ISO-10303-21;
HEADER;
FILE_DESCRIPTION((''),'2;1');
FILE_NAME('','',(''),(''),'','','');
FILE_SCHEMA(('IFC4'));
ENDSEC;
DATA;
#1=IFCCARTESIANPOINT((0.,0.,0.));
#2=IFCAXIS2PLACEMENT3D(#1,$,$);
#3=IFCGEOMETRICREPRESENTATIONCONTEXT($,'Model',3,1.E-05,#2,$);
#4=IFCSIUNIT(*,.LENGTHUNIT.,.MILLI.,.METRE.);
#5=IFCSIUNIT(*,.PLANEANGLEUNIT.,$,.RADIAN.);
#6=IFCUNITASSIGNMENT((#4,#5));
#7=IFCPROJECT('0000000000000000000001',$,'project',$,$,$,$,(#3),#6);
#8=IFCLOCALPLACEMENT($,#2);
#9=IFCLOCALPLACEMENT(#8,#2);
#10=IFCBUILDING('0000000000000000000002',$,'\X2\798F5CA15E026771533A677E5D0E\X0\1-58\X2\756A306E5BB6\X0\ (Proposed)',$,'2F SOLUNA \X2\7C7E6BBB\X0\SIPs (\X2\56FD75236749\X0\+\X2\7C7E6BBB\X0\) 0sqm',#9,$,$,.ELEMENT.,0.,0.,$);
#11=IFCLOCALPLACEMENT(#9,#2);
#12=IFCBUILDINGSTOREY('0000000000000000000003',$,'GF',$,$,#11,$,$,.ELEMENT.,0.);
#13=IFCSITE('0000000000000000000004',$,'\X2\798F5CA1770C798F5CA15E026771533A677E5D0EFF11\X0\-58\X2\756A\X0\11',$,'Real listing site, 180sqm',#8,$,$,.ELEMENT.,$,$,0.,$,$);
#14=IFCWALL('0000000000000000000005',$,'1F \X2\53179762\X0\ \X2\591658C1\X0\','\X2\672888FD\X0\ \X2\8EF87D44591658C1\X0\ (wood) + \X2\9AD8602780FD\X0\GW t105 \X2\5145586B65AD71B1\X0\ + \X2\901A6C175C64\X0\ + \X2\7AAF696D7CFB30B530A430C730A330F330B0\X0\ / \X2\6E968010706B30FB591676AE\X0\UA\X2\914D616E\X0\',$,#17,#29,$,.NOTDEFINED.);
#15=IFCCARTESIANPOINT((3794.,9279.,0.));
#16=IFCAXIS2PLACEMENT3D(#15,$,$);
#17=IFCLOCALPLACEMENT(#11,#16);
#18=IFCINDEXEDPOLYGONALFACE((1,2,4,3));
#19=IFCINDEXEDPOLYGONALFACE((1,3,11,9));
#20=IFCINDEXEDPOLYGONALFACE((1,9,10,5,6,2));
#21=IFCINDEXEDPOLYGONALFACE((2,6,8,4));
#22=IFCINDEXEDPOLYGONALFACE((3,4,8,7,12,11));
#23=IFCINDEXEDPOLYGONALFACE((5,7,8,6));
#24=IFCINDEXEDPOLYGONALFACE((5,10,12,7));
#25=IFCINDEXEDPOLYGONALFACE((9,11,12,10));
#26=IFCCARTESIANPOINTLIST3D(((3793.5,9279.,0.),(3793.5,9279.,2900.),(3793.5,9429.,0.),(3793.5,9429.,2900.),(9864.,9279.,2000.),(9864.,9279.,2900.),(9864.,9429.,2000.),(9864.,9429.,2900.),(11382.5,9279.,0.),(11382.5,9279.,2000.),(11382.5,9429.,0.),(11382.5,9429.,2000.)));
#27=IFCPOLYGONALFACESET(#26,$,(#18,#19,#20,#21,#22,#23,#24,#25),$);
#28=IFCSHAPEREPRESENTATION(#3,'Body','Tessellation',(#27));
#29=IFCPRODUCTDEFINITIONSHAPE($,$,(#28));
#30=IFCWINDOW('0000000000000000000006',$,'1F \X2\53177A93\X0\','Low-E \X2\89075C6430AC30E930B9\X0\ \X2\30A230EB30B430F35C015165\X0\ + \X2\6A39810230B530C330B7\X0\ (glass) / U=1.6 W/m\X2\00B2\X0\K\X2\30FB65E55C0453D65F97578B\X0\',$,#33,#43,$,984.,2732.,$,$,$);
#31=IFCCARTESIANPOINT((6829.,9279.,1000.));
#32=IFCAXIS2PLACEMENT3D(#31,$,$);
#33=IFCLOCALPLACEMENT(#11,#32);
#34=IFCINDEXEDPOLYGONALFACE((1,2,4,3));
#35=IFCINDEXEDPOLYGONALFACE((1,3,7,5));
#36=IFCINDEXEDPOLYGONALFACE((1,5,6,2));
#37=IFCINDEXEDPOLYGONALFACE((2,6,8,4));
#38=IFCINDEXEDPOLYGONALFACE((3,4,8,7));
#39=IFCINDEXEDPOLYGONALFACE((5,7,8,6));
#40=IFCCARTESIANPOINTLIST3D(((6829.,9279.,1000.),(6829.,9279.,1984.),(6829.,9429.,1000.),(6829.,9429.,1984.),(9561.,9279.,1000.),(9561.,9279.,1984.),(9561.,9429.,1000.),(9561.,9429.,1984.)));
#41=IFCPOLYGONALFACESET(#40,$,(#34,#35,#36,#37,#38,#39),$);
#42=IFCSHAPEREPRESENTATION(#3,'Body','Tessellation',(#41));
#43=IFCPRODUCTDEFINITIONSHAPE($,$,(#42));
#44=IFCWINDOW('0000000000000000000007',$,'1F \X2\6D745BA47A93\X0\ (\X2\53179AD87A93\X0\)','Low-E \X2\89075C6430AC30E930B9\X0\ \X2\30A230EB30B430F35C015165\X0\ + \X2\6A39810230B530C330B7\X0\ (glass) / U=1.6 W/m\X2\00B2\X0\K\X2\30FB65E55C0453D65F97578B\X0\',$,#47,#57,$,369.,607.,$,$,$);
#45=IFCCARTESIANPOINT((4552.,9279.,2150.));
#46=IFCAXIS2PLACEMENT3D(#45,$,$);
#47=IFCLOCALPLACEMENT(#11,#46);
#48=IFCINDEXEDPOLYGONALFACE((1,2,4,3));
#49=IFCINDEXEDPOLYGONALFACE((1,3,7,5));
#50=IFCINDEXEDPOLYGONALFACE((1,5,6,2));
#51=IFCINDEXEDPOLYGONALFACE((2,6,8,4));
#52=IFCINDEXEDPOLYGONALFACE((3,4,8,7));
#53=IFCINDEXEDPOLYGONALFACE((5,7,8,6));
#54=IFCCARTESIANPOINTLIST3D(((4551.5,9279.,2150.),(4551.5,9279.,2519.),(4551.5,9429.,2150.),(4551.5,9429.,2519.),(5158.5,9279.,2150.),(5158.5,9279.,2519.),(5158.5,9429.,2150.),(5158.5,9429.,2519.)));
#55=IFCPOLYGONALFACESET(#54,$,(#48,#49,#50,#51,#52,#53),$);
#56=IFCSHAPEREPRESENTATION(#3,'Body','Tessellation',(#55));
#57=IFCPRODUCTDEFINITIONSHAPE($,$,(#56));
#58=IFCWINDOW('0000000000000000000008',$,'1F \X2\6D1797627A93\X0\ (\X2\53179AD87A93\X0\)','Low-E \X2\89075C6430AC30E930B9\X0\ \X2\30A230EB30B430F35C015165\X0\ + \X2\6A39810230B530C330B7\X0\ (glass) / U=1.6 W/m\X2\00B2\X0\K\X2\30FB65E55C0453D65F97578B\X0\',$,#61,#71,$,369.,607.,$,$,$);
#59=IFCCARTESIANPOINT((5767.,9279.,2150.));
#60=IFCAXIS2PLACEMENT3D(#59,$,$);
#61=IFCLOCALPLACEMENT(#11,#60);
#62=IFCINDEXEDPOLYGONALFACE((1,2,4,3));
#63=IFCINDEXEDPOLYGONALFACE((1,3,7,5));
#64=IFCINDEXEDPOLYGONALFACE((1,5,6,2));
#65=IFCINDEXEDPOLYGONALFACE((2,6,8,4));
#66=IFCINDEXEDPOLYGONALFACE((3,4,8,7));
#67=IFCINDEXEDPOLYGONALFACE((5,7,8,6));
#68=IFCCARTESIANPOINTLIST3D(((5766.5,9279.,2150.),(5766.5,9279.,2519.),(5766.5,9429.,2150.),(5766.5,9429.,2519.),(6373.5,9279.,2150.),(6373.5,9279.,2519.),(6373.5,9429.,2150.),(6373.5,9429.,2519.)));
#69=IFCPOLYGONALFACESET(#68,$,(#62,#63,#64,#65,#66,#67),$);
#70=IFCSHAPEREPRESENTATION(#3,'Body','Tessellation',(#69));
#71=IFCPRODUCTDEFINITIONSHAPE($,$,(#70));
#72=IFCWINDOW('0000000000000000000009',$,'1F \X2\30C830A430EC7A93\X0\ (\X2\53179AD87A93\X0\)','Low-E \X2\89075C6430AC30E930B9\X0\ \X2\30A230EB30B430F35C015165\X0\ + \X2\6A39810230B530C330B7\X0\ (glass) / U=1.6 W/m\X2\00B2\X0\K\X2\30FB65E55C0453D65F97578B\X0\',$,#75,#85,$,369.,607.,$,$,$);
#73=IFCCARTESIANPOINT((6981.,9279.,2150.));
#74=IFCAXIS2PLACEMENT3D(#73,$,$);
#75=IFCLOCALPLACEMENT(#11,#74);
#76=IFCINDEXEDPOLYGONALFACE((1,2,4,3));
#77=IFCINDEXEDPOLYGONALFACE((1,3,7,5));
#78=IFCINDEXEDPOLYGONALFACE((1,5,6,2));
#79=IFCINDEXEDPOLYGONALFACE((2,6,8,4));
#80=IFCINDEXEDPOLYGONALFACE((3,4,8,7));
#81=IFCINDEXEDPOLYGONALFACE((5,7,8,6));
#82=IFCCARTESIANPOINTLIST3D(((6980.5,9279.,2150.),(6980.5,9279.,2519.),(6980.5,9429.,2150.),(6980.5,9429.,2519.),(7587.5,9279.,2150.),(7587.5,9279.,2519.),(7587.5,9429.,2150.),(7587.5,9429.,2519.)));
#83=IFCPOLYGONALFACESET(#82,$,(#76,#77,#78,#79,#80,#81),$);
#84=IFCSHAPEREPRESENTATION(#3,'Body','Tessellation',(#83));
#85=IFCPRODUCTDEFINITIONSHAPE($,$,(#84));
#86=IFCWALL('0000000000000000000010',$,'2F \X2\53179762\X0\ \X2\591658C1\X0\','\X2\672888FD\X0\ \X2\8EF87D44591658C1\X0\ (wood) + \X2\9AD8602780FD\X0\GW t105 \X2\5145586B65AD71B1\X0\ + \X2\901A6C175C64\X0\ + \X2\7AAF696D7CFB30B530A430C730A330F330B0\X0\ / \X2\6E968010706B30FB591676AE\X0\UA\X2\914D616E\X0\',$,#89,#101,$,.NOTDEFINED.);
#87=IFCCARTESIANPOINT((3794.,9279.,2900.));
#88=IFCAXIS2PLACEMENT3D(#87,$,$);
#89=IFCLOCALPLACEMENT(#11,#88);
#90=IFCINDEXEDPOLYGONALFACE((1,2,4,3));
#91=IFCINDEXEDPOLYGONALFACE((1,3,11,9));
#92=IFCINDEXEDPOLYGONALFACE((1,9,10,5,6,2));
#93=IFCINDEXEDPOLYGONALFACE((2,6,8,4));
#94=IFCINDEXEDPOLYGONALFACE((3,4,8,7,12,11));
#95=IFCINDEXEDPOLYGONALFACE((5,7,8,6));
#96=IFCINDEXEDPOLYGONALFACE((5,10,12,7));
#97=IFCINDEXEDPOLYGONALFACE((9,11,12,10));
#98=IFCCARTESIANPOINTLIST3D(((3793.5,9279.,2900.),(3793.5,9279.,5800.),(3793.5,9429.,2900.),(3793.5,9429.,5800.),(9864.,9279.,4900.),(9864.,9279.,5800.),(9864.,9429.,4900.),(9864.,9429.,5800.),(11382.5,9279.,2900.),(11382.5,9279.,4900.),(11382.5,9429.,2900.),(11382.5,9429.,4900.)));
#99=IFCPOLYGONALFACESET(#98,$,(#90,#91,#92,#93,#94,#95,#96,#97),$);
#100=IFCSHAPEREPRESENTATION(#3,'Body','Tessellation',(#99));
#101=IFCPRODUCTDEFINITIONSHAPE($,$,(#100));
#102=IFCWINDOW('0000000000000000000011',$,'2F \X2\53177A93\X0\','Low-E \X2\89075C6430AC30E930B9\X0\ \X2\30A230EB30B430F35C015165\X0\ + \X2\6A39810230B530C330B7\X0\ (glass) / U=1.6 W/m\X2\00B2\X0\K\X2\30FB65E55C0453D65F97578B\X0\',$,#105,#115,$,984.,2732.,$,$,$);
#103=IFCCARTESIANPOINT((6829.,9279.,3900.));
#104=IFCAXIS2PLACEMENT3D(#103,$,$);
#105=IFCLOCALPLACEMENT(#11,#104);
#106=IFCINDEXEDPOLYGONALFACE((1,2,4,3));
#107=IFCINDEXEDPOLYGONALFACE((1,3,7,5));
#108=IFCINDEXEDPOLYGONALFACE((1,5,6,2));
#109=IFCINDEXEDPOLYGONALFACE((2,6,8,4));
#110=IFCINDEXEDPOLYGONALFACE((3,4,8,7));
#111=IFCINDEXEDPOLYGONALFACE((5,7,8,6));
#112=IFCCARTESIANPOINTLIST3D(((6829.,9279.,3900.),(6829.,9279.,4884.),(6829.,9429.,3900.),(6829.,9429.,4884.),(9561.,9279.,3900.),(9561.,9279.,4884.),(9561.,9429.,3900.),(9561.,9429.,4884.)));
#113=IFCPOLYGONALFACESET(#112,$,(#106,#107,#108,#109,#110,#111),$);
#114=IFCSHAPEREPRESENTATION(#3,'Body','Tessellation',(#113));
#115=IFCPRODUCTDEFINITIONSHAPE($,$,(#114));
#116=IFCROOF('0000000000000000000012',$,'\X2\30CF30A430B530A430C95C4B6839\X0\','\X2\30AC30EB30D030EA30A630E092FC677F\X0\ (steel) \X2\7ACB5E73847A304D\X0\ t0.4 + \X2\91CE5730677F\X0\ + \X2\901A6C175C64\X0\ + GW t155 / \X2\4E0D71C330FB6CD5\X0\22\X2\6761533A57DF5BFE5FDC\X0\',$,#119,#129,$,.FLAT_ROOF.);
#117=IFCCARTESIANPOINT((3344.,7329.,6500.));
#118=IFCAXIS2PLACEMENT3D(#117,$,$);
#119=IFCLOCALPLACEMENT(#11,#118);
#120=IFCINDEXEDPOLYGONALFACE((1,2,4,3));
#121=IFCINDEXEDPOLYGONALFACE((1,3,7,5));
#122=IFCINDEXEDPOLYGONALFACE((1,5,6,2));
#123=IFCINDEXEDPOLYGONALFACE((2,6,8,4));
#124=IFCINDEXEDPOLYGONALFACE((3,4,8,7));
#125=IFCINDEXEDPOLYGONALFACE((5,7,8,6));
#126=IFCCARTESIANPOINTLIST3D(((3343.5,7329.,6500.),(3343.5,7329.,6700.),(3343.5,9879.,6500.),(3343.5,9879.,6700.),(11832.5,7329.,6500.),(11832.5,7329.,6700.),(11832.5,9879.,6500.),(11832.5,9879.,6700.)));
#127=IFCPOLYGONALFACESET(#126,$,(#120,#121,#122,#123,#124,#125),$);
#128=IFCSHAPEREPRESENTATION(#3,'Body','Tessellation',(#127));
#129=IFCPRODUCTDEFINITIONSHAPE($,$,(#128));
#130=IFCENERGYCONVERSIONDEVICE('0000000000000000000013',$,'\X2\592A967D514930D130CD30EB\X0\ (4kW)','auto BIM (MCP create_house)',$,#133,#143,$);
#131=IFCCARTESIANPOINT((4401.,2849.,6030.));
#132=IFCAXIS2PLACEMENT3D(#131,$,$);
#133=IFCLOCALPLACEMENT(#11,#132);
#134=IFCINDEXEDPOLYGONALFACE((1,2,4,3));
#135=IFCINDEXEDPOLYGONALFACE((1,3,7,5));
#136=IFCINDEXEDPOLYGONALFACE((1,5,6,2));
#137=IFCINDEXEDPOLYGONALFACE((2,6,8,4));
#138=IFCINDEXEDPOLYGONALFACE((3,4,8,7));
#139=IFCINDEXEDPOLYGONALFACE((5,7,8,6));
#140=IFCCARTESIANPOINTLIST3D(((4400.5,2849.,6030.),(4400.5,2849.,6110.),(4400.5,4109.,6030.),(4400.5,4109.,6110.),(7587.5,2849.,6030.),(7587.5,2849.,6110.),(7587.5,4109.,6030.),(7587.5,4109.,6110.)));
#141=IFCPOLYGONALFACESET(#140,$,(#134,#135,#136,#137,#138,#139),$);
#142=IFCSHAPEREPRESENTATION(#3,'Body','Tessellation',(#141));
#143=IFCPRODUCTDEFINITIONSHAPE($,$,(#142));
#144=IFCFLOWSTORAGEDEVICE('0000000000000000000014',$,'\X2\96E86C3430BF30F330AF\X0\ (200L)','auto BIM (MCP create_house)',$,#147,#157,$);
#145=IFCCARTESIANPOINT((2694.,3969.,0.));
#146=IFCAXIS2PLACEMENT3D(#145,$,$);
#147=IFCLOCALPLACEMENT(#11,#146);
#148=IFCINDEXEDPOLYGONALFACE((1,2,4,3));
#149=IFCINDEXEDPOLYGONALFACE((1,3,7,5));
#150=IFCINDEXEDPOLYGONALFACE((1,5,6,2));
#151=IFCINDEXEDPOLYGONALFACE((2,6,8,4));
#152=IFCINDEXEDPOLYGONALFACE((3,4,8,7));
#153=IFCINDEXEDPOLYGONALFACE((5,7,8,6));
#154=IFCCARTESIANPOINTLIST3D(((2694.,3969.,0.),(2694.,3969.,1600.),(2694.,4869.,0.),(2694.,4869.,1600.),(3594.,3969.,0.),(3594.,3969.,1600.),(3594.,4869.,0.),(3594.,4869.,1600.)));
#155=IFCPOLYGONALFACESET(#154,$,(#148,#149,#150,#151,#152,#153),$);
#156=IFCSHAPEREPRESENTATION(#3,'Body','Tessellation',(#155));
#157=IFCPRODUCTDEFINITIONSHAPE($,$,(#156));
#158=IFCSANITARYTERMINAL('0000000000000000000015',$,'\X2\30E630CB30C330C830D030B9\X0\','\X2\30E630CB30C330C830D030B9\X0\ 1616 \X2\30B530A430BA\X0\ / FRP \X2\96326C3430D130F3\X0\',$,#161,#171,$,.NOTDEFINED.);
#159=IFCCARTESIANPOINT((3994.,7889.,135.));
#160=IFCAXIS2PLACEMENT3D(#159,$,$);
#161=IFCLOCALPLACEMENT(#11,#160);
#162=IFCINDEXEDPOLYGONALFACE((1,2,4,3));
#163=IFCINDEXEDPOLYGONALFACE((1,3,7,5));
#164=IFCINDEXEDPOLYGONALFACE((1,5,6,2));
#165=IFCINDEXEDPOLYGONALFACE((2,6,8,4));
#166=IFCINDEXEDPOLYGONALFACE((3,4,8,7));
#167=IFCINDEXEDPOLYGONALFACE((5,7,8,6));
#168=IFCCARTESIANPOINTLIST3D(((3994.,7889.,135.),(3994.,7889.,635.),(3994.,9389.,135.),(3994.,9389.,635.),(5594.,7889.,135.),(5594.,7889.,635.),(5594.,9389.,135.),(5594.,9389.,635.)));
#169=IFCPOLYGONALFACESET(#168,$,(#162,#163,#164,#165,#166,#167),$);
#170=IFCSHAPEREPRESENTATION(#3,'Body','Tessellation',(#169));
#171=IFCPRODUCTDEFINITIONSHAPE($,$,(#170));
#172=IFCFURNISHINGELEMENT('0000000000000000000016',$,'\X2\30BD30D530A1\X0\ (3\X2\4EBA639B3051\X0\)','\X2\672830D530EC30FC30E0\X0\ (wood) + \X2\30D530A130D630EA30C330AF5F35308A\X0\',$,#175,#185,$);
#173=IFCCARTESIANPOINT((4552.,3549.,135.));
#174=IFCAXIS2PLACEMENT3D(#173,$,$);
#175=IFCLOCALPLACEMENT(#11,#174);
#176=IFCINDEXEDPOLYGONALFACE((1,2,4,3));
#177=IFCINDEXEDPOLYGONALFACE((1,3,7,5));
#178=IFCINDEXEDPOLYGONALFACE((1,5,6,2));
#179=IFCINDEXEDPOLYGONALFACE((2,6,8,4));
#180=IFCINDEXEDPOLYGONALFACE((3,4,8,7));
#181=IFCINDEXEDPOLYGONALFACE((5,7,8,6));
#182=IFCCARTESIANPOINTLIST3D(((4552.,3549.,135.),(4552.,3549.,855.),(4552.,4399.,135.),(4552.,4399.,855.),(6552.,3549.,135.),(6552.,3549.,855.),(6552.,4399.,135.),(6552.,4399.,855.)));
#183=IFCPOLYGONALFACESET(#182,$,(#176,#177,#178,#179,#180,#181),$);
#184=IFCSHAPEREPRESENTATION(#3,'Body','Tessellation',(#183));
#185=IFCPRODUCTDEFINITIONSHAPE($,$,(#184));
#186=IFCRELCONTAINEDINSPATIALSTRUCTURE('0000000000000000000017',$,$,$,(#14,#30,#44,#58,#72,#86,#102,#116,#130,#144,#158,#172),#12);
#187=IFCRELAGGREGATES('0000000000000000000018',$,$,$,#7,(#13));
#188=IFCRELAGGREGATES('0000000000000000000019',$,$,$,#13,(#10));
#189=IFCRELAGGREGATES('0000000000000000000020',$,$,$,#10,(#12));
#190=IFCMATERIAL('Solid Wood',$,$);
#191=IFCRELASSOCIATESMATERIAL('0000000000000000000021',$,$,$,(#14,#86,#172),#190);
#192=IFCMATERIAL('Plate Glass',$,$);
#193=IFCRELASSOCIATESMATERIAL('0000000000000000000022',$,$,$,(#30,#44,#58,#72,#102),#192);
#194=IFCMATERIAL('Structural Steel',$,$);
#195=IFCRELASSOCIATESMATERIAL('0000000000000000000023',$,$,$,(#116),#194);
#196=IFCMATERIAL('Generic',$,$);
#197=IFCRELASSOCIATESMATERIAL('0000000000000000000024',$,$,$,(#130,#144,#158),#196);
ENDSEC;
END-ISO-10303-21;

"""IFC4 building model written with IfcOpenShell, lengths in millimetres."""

from ifc_helpers import new_model, si_unit, frame, frame_2d, origin, place, context, project, spatial, rectangle, extrude, material, element, fill, save


model = new_model("IFC4")

# Units and contexts
model_context = context("Model", 3, precision=1e-05, world=origin())
ifc_project = project(units=[si_unit("LENGTHUNIT", "METRE", prefix="MILLI"), si_unit("PLANEANGLEUNIT", "RADIAN")], contexts=[model_context])

# Site, building, storey
site_placement = place(None, origin())
site = spatial("IfcSite", under=ifc_project, at=site_placement, Name="福岡県福岡市東区松崎１-58番11", ObjectType="Real listing site, 180sqm", CompositionType="ELEMENT", RefElevation=0.0)
building_placement = place(site_placement, origin())
building = spatial("IfcBuilding", under=site, at=building_placement, Name="福岡市東区松崎1-58番の家 (Proposed)", ObjectType="2F SOLUNA 籾殻SIPs (国産杉+籾殻) 0sqm", CompositionType="ELEMENT", ElevationOfRefHeight=0.0, ElevationOfTerrain=0.0)
storey_placement = place(building_placement, origin())
storey = spatial("IfcBuildingStorey", under=building, at=storey_placement, Name="GF", CompositionType="ELEMENT", Elevation=0.0)

# Wall, openings, windows
ifc_material_1 = material(Name="Solid Wood")
wall_1_placement = place(storey_placement, frame((3794.0, 9279.0, 0.0)))
wall_1 = element("IfcWall", 1, at=wall_1_placement, inside=storey, material=ifc_material_1, Name="1F 北面 外壁", Description="木製 軸組外壁 (wood) + 高性能GW t105 充填断熱 + 通気層 + 窯業系サイディング / 準耐火・外皮UA配慮", PredefinedType="NOTDEFINED", context=model_context, shape_type="SweptSolid", body=[
    extrude(rectangle(XDim=7589.0, YDim=150.0, at=frame_2d((3794.0, 75.0))), frame((3794.0, 9279.0, 0.0)), (0.0, 0.0, 1.0), 2900.0),
])
opening_1_placement = place(storey_placement, frame((6829.0, 9279.0, 1000.0)))
opening_1 = element("IfcOpeningElement", 2, at=opening_1_placement, cuts=wall_1, PredefinedType="NOTDEFINED", context=model_context, shape_type="SweptSolid", body=[
    extrude(rectangle(XDim=2732.0, YDim=150.0, at=frame_2d((1366.0, 75.0))), frame((6829.0, 9279.0, 1000.0)), (0.0, 0.0, 1.0), 984.0),
])
opening_2_placement = place(storey_placement, frame((4552.0, 9279.0, 2150.0)))
opening_2 = element("IfcOpeningElement", 3, at=opening_2_placement, cuts=wall_1, PredefinedType="NOTDEFINED", context=model_context, shape_type="SweptSolid", body=[
    extrude(rectangle(XDim=607.0, YDim=150.0, at=frame_2d((303.0, 75.0))), frame((4552.0, 9279.0, 2150.0)), (0.0, 0.0, 1.0), 369.0),
])
opening_3_placement = place(storey_placement, frame((5767.0, 9279.0, 2150.0)))
opening_3 = element("IfcOpeningElement", 4, at=opening_3_placement, cuts=wall_1, PredefinedType="NOTDEFINED", context=model_context, shape_type="SweptSolid", body=[
    extrude(rectangle(XDim=607.0, YDim=150.0, at=frame_2d((303.0, 75.0))), frame((5767.0, 9279.0, 2150.0)), (0.0, 0.0, 1.0), 369.0),
])
opening_4_placement = place(storey_placement, frame((6981.0, 9279.0, 2150.0)))
opening_4 = element("IfcOpeningElement", 5, at=opening_4_placement, cuts=wall_1, PredefinedType="NOTDEFINED", context=model_context, shape_type="SweptSolid", body=[
    extrude(rectangle(XDim=607.0, YDim=150.0, at=frame_2d((303.0, 75.0))), frame((6981.0, 9279.0, 2150.0)), (0.0, 0.0, 1.0), 369.0),
])
ifc_material_2 = material(Name="Plate Glass")
window_1_placement = place(storey_placement, frame((6829.0, 9279.0, 1000.0)))
window_1 = element("IfcWindow", 6, at=window_1_placement, inside=storey, material=ifc_material_2, Name="1F 北窓", Description="Low-E 複層ガラス アルゴン封入 + 樹脂サッシ (glass) / U=1.6 W/m²K・日射取得型", OverallHeight=984.0, OverallWidth=2732.0, context=model_context, shape_type="SweptSolid", body=[
    extrude(rectangle(XDim=2732.0, YDim=150.0, at=frame_2d((1366.0, 75.0))), frame((6829.0, 9279.0, 1000.0)), (0.0, 0.0, 1.0), 984.0),
])
fill(opening_1, window_1)
window_2_placement = place(storey_placement, frame((4552.0, 9279.0, 2150.0)))
window_2 = element("IfcWindow", 7, at=window_2_placement, inside=storey, material=ifc_material_2, Name="1F 浴室窓 (北高窓)", Description="Low-E 複層ガラス アルゴン封入 + 樹脂サッシ (glass) / U=1.6 W/m²K・日射取得型", OverallHeight=369.0, OverallWidth=607.0, context=model_context, shape_type="SweptSolid", body=[
    extrude(rectangle(XDim=607.0, YDim=150.0, at=frame_2d((303.0, 75.0))), frame((4552.0, 9279.0, 2150.0)), (0.0, 0.0, 1.0), 369.0),
])
fill(opening_2, window_2)
window_3_placement = place(storey_placement, frame((5767.0, 9279.0, 2150.0)))
window_3 = element("IfcWindow", 8, at=window_3_placement, inside=storey, material=ifc_material_2, Name="1F 洗面窓 (北高窓)", Description="Low-E 複層ガラス アルゴン封入 + 樹脂サッシ (glass) / U=1.6 W/m²K・日射取得型", OverallHeight=369.0, OverallWidth=607.0, context=model_context, shape_type="SweptSolid", body=[
    extrude(rectangle(XDim=607.0, YDim=150.0, at=frame_2d((303.0, 75.0))), frame((5767.0, 9279.0, 2150.0)), (0.0, 0.0, 1.0), 369.0),
])
fill(opening_3, window_3)
window_4_placement = place(storey_placement, frame((6981.0, 9279.0, 2150.0)))
window_4 = element("IfcWindow", 9, at=window_4_placement, inside=storey, material=ifc_material_2, Name="1F トイレ窓 (北高窓)", Description="Low-E 複層ガラス アルゴン封入 + 樹脂サッシ (glass) / U=1.6 W/m²K・日射取得型", OverallHeight=369.0, OverallWidth=607.0, context=model_context, shape_type="SweptSolid", body=[
    extrude(rectangle(XDim=607.0, YDim=150.0, at=frame_2d((303.0, 75.0))), frame((6981.0, 9279.0, 2150.0)), (0.0, 0.0, 1.0), 369.0),
])
fill(opening_4, window_4)

# Wall, opening, window
wall_2_placement = place(storey_placement, frame((3794.0, 9279.0, 2900.0)))
wall_2 = element("IfcWall", 10, at=wall_2_placement, inside=storey, material=ifc_material_1, Name="2F 北面 外壁", Description="木製 軸組外壁 (wood) + 高性能GW t105 充填断熱 + 通気層 + 窯業系サイディング / 準耐火・外皮UA配慮", PredefinedType="NOTDEFINED", context=model_context, shape_type="SweptSolid", body=[
    extrude(rectangle(XDim=7589.0, YDim=150.0, at=frame_2d((3794.0, 75.0))), frame((3794.0, 9279.0, 2900.0)), (0.0, 0.0, 1.0), 2900.0),
])
opening_5_placement = place(storey_placement, frame((6829.0, 9279.0, 3900.0)))
opening_5 = element("IfcOpeningElement", 11, at=opening_5_placement, cuts=wall_2, PredefinedType="NOTDEFINED", context=model_context, shape_type="SweptSolid", body=[
    extrude(rectangle(XDim=2732.0, YDim=150.0, at=frame_2d((1366.0, 75.0))), frame((6829.0, 9279.0, 3900.0)), (0.0, 0.0, 1.0), 984.0),
])
window_5_placement = place(storey_placement, frame((6829.0, 9279.0, 3900.0)))
window_5 = element("IfcWindow", 12, at=window_5_placement, inside=storey, material=ifc_material_2, Name="2F 北窓", Description="Low-E 複層ガラス アルゴン封入 + 樹脂サッシ (glass) / U=1.6 W/m²K・日射取得型", OverallHeight=984.0, OverallWidth=2732.0, context=model_context, shape_type="SweptSolid", body=[
    extrude(rectangle(XDim=2732.0, YDim=150.0, at=frame_2d((1366.0, 75.0))), frame((6829.0, 9279.0, 3900.0)), (0.0, 0.0, 1.0), 984.0),
])
fill(opening_5, window_5)

# Roof
ifc_material_3 = material(Name="Structural Steel")
roof_placement = place(storey_placement, frame((3344.0, 7329.0, 6500.0)))
element("IfcRoof", 13, at=roof_placement, inside=storey, material=ifc_material_3, Name="ハイサイド屋根", Description="ガルバリウム鋼板 (steel) 立平葺き t0.4 + 野地板 + 通気層 + GW t155 / 不燃・法22条区域対応", PredefinedType="FLAT_ROOF", context=model_context, shape_type="SweptSolid", body=[
    extrude(rectangle(XDim=8489.0, YDim=2550.0, at=frame_2d((4244.0, 1275.0))), frame((3344.0, 7329.0, 6500.0)), (0.0, 0.0, 1.0), 200.0),
])

# Energy conversion device
ifc_material_4 = material(Name="Generic")
energy_conversion_device_placement = place(storey_placement, frame((4401.0, 2849.0, 6030.0)))
element("IfcEnergyConversionDevice", 14, at=energy_conversion_device_placement, inside=storey, material=ifc_material_4, Name="太陽光パネル (4kW)", Description="auto BIM (MCP create_house)", context=model_context, shape_type="SweptSolid", body=[
    extrude(rectangle(XDim=3187.0, YDim=1260.0, at=frame_2d((1593.0, 630.0))), frame((4401.0, 2849.0, 6030.0)), (0.0, 0.0, 1.0), 80.0),
])

# Flow storage device
flow_storage_device_placement = place(storey_placement, frame((2694.0, 3969.0, 0.0)))
element("IfcFlowStorageDevice", 15, at=flow_storage_device_placement, inside=storey, material=ifc_material_4, Name="雨水タンク (200L)", Description="auto BIM (MCP create_house)", context=model_context, shape_type="SweptSolid", body=[
    extrude(rectangle(XDim=900.0, YDim=900.0, at=frame_2d((450.0, 450.0))), frame((2694.0, 3969.0, 0.0)), (0.0, 0.0, 1.0), 1600.0),
])

# Sanitary terminal
sanitary_terminal_placement = place(storey_placement, frame((3994.0, 7889.0, 135.0)))
element("IfcSanitaryTerminal", 16, at=sanitary_terminal_placement, inside=storey, material=ifc_material_4, Name="ユニットバス", Description="ユニットバス 1616 サイズ / FRP 防水パン", PredefinedType="NOTDEFINED", context=model_context, shape_type="SweptSolid", body=[
    extrude(rectangle(XDim=1600.0, YDim=1500.0, at=frame_2d((800.0, 750.0))), frame((3994.0, 7889.0, 135.0)), (0.0, 0.0, 1.0), 500.0),
])

# Furnishing element
furnishing_1_placement = place(storey_placement, frame((4552.0, 3549.0, 135.0)))
element("IfcFurnishingElement", 17, at=furnishing_1_placement, inside=storey, material=ifc_material_1, Name="ソファ (3人掛け)", Description="木フレーム (wood) + ファブリック張り", context=model_context, shape_type="SweptSolid", body=[
    extrude(rectangle(XDim=2000.0, YDim=850.0, at=frame_2d((1000.0, 425.0))), frame((4552.0, 3549.0, 135.0)), (0.0, 0.0, 1.0), 720.0),
])

save(model, "model.ifc")
